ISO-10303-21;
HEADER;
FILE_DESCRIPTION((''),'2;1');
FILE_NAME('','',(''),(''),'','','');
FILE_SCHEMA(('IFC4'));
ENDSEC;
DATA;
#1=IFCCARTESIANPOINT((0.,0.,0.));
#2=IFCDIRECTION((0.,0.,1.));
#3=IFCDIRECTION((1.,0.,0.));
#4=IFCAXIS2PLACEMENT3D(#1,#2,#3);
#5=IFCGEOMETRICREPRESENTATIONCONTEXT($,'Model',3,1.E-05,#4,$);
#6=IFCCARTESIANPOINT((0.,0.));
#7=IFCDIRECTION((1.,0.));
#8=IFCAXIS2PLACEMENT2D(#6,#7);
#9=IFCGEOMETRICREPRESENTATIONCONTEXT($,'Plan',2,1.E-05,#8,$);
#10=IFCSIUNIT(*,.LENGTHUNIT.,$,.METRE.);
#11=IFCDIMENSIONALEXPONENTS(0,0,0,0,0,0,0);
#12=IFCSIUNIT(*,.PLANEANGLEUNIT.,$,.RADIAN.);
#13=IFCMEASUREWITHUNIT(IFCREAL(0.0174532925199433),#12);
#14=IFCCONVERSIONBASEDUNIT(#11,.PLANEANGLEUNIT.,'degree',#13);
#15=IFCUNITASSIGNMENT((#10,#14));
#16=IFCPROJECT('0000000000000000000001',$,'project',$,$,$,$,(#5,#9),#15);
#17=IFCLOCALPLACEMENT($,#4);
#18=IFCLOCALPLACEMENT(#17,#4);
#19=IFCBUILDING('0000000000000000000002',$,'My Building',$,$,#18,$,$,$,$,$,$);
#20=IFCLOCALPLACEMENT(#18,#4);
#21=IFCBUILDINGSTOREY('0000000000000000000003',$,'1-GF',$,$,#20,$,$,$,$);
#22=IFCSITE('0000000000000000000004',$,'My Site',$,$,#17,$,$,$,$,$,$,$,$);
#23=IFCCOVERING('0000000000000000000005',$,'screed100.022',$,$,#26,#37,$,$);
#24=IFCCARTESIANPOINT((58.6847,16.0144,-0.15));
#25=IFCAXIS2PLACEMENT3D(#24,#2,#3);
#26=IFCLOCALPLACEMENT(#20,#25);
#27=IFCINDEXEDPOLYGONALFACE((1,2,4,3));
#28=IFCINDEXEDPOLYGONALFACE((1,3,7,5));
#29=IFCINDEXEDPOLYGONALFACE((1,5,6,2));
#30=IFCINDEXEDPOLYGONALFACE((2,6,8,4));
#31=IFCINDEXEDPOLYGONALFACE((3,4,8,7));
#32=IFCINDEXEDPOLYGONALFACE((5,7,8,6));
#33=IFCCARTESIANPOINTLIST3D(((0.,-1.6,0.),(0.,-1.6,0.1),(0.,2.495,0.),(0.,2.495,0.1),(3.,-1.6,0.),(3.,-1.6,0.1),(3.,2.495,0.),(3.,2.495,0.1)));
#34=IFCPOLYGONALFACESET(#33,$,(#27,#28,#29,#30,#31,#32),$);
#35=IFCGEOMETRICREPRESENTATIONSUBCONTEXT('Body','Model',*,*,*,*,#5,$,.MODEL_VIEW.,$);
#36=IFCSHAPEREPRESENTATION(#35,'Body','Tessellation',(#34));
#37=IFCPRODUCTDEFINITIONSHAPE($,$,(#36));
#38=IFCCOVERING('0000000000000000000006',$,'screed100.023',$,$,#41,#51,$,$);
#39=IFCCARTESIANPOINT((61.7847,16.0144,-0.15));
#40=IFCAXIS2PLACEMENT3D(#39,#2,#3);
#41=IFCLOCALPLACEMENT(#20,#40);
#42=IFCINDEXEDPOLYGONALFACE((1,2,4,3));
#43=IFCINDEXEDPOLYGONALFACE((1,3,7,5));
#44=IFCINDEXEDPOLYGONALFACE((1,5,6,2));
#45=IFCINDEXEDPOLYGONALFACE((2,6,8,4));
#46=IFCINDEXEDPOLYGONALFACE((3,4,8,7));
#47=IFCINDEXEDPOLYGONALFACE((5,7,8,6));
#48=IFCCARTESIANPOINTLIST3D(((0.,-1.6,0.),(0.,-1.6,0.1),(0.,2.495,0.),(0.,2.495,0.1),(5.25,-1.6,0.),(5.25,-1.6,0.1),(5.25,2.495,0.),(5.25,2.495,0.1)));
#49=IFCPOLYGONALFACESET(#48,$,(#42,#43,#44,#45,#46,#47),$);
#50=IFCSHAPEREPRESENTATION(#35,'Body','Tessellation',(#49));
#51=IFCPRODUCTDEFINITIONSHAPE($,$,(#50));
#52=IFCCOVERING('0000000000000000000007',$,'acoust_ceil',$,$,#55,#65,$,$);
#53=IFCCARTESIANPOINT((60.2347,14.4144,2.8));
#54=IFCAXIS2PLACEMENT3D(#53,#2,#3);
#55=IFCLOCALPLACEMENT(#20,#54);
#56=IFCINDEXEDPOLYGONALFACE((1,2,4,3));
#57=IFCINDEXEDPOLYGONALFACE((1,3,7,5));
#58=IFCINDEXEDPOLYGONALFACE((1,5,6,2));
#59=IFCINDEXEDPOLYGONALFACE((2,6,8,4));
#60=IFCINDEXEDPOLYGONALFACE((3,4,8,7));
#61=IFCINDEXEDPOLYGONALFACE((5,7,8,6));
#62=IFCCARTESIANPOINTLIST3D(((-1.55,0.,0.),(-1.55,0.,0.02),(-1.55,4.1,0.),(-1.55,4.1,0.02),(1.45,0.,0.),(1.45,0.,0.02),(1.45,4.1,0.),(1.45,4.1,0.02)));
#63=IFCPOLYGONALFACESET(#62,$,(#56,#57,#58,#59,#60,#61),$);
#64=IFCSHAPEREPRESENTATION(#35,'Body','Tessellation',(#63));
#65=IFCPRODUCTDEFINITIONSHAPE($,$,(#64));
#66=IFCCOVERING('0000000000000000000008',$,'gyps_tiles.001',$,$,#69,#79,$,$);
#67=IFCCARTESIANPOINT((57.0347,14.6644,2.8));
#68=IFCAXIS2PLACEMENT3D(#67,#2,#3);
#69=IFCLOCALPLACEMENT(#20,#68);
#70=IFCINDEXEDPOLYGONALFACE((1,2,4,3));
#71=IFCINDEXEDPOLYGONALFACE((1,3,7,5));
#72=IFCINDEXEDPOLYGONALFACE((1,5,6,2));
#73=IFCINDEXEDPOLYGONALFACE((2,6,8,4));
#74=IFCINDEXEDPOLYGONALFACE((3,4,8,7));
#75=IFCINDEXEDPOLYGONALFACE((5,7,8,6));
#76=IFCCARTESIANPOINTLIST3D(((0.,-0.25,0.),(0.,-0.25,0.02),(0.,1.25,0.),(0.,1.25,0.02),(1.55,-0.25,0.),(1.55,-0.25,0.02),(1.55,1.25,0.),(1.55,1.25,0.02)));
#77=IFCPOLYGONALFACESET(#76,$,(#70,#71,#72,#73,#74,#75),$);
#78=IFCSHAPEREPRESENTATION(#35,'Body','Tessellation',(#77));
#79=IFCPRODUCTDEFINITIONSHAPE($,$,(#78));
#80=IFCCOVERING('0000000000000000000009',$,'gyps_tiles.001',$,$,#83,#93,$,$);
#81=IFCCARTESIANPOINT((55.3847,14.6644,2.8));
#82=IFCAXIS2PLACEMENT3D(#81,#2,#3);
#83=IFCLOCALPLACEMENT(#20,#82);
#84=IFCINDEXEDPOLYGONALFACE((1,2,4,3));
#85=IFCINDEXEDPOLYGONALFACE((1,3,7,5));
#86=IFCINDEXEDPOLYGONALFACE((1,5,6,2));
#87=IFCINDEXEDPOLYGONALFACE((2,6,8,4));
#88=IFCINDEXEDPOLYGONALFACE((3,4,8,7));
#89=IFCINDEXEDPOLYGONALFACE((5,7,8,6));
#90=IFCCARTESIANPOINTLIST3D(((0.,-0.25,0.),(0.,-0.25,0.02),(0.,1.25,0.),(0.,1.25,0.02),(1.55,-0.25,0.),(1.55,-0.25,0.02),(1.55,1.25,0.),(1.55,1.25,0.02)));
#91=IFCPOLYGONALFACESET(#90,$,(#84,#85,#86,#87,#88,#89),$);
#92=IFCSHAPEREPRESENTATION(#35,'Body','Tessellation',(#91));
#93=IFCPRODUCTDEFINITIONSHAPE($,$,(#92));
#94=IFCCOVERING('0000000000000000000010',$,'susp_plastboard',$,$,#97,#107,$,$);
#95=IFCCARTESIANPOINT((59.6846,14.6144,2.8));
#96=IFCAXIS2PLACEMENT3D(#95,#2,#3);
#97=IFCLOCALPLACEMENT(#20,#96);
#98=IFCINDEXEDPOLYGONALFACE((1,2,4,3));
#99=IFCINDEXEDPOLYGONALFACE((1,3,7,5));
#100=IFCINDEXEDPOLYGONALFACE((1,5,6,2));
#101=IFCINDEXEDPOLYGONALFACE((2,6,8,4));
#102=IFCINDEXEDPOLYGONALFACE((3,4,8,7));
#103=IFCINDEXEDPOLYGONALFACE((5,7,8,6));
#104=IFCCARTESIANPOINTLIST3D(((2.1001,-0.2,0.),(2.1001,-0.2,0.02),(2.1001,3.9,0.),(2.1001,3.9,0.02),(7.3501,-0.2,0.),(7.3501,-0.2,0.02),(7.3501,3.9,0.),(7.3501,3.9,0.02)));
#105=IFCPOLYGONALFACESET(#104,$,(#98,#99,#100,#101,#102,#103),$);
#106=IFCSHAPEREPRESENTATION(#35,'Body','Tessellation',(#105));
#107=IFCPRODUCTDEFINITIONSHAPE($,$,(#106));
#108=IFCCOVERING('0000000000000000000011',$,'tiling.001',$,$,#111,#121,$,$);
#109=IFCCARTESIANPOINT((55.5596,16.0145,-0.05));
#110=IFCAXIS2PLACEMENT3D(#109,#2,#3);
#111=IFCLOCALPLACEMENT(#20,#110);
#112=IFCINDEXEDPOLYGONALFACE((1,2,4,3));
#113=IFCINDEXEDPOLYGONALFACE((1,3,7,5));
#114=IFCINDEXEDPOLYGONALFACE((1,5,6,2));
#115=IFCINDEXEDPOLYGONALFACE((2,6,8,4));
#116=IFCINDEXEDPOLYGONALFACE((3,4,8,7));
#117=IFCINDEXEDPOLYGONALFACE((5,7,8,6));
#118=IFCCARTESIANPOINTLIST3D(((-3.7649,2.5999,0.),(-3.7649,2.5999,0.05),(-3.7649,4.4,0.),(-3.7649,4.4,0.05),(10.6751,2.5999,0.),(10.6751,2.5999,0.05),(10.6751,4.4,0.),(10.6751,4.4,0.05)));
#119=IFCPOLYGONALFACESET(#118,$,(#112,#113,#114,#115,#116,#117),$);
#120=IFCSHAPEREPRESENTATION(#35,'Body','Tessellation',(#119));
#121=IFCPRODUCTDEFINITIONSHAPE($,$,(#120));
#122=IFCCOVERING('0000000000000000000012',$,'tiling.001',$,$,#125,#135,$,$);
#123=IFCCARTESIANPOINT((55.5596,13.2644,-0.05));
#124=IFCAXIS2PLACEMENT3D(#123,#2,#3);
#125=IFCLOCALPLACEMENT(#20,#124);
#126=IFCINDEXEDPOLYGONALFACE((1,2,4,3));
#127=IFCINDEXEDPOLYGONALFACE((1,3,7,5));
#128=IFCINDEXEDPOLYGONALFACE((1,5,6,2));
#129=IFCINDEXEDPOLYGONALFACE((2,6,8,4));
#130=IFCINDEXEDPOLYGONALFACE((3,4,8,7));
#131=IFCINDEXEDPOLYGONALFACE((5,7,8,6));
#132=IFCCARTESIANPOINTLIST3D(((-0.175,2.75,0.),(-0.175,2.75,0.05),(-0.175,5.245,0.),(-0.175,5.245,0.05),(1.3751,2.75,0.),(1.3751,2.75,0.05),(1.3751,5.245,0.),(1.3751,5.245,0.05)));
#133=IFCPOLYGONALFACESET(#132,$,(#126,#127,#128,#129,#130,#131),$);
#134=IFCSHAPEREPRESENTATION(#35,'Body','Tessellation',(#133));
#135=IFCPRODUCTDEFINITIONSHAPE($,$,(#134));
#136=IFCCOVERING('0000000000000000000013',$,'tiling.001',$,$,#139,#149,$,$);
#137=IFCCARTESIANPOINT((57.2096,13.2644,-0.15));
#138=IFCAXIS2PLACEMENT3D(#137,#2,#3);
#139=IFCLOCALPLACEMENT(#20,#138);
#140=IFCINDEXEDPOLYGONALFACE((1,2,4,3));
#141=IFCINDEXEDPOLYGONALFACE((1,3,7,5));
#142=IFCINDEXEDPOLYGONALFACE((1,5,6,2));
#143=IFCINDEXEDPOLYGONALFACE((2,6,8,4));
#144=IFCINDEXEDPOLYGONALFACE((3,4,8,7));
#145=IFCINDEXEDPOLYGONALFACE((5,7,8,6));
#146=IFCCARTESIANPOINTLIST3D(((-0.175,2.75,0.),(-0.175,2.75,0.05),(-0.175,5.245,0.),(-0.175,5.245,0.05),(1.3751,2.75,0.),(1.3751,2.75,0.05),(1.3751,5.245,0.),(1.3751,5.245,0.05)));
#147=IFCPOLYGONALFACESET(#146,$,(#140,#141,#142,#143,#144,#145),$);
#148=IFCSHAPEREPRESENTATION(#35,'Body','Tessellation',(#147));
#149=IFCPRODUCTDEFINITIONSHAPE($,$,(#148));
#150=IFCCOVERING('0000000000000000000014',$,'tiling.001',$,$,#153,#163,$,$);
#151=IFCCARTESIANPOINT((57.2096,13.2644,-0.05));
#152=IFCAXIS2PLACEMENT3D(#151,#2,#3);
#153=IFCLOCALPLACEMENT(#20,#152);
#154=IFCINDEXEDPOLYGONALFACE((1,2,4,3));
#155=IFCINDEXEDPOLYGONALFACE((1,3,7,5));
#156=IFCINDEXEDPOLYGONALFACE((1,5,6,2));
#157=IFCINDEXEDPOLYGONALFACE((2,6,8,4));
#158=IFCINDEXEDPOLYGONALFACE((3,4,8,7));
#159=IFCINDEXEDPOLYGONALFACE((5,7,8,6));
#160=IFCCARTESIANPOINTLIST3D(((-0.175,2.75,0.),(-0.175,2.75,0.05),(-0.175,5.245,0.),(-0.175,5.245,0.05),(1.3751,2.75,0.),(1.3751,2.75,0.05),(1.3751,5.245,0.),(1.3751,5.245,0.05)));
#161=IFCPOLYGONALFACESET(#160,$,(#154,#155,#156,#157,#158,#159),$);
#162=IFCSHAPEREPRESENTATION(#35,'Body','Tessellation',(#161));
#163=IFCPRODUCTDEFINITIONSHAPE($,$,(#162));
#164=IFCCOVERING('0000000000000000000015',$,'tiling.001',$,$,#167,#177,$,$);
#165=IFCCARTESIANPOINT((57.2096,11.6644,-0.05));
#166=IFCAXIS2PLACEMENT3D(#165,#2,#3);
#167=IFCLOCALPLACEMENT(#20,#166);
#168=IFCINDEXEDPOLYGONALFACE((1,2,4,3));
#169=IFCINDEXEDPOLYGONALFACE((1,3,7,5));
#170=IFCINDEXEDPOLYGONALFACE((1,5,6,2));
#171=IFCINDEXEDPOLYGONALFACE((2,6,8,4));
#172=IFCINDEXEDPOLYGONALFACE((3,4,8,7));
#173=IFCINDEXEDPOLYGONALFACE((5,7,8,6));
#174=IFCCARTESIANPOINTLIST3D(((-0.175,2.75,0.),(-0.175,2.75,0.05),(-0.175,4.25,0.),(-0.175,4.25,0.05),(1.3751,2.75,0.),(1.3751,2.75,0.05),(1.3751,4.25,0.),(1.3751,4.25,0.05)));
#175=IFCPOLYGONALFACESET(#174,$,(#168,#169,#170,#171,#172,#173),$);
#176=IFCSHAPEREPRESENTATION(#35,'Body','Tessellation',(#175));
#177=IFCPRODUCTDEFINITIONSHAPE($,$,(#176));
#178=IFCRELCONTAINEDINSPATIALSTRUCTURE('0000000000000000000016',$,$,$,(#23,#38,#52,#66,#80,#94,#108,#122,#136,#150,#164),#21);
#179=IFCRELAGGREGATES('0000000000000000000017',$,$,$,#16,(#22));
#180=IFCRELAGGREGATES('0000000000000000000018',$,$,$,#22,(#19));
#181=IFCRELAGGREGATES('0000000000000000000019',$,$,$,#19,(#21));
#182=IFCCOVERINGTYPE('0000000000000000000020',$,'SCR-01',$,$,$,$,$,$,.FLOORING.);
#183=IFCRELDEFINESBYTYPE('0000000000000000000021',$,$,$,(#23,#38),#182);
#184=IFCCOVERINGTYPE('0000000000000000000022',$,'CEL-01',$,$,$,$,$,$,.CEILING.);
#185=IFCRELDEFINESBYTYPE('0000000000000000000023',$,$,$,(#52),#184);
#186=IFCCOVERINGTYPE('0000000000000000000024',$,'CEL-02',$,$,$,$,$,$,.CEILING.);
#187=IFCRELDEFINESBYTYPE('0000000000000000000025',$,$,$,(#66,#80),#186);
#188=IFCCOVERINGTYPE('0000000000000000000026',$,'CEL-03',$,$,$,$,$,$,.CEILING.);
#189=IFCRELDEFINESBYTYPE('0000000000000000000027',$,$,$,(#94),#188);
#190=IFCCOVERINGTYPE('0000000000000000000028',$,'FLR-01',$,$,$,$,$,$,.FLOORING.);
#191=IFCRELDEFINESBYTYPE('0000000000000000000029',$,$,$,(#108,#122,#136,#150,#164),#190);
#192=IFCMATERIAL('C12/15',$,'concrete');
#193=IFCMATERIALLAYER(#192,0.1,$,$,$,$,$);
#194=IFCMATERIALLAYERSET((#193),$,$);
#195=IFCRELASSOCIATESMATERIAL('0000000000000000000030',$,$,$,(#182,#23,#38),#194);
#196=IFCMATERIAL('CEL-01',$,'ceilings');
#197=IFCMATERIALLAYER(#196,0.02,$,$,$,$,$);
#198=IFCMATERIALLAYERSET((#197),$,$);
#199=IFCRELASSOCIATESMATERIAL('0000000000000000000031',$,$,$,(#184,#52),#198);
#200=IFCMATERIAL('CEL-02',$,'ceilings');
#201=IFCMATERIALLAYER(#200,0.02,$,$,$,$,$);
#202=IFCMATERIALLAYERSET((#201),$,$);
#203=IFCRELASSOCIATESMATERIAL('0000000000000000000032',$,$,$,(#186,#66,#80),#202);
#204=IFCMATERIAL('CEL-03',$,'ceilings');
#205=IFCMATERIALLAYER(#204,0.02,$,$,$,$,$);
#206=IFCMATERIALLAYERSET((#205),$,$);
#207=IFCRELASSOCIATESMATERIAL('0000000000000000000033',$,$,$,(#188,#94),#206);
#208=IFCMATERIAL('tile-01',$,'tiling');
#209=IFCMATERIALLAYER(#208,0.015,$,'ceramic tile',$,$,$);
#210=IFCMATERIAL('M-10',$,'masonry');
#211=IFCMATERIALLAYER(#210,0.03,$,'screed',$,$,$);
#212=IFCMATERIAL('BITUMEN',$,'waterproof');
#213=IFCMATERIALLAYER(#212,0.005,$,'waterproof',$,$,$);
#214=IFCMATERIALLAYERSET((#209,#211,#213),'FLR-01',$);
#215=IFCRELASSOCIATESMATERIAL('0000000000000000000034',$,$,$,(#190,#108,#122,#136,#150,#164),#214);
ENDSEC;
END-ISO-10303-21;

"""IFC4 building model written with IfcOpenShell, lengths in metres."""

from ifc_helpers import new_model, entity, si_unit, converted_unit, frame, origin_with_axes, origin_2d_with_axis, place, context, subcontext, project, spatial, line, indexed_curve, outline, extrude, material, layer, layer_set, layer_usage, type_object, element, save


model = new_model("IFC4")

# Units and contexts
model_context = context("Model", 3, precision=1e-05, world=origin_with_axes())
plan_context = context("Plan", 2, precision=1e-05, world=origin_2d_with_axis())
body_context_1 = subcontext(model_context, "Body", "Model", "MODEL_VIEW")
ifc_project = project(units=[si_unit("LENGTHUNIT", "METRE"), converted_unit("PLANEANGLEUNIT", "degree", entity("IfcReal", 0.0174532925199433), si_unit("PLANEANGLEUNIT", "RADIAN"), dimensions=[0, 0, 0, 0, 0, 0, 0])], contexts=[model_context, plan_context])

# Site, building, storey
site_placement = place(None, origin_with_axes())
site = spatial("IfcSite", under=ifc_project, at=site_placement, Name="My Site")
building_placement = place(site_placement, origin_with_axes())
building = spatial("IfcBuilding", under=site, at=building_placement, Name="My Building")
storey_placement = place(building_placement, origin_with_axes())
storey = spatial("IfcBuildingStorey", under=building, at=storey_placement, Name="1-GF")

# Coverings
ifc_material_1 = material(Name="C12/15", Category="concrete")
ifc_layer_1 = layer(ifc_material_1, 0.1)
ifc_layer_set_1 = layer_set([ifc_layer_1])
covering_type_1 = type_object("IfcCoveringType", Name="SCR-01", PredefinedType="FLOORING", material=ifc_layer_set_1)
ifc_layer_usage_1 = layer_usage(ifc_layer_set_1, "AXIS3", "POSITIVE", 0.0)
covering_1_placement = place(storey_placement, frame((58.6847, 16.0144, -0.15), z_axis=(0.0, 0.0, 1.0), x_axis=(1.0, 0.0, 0.0)))
element("IfcCovering", 1, at=covering_1_placement, inside=storey, type_object=covering_type_1, material=ifc_layer_usage_1, Name="screed100.022", context=body_context_1, shape_type="SweptSolid", body=[
    extrude(outline(indexed_curve([(3.0, 2.495), (3.0, -1.6), (0.0, -1.6), (0.0, 2.495)], segments=[line(4, 1), line(1, 2), line(2, 3), line(3, 4)], self_intersect=False)), None, (0.0, 0.0, 1.0), 0.1),
])
ifc_layer_usage_2 = layer_usage(ifc_layer_set_1, "AXIS3", "POSITIVE", 0.0)
covering_2_placement = place(storey_placement, frame((61.7847, 16.0144, -0.15), z_axis=(0.0, 0.0, 1.0), x_axis=(1.0, 0.0, 0.0)))
element("IfcCovering", 2, at=covering_2_placement, inside=storey, type_object=covering_type_1, material=ifc_layer_usage_2, Name="screed100.023", context=body_context_1, shape_type="SweptSolid", body=[
    extrude(outline(indexed_curve([(0.0, 2.495), (5.25, 2.495), (5.25, -1.6), (0.0, -1.6)], segments=[line(3, 2), line(2, 1), line(1, 4), line(4, 3)], self_intersect=False)), None, (0.0, 0.0, 1.0), 0.1),
])
ifc_material_2 = material(Name="CEL-01", Category="ceilings")
ifc_layer_2 = layer(ifc_material_2, 0.02)
ifc_layer_set_2 = layer_set([ifc_layer_2])
ifc_layer_usage_3 = layer_usage(ifc_layer_set_2, "AXIS3", "POSITIVE", 0.0)
covering_type_2 = type_object("IfcCoveringType", Name="CEL-01", PredefinedType="CEILING", material=ifc_layer_set_2)
covering_3_placement = place(storey_placement, frame((60.2347, 14.4144, 2.8), z_axis=(0.0, 0.0, 1.0), x_axis=(1.0, 0.0, 0.0)))
element("IfcCovering", 3, at=covering_3_placement, inside=storey, type_object=covering_type_2, material=ifc_layer_usage_3, Name="acoust_ceil", context=body_context_1, shape_type="SweptSolid", body=[
    extrude(outline(indexed_curve([(-1.55, 0.0), (1.45, 0.0), (1.45, 4.1), (-1.55, 4.1)], segments=[line(3, 2), line(2, 1), line(1, 4), line(4, 3)], self_intersect=False)), None, (0.0, 0.0, 1.0), 0.02),
])
ifc_material_3 = material(Name="CEL-02", Category="ceilings")
ifc_layer_3 = layer(ifc_material_3, 0.02)
ifc_layer_set_3 = layer_set([ifc_layer_3])
ifc_layer_usage_4 = layer_usage(ifc_layer_set_3, "AXIS3", "POSITIVE", 0.0)
covering_type_3 = type_object("IfcCoveringType", Name="CEL-02", PredefinedType="CEILING", material=ifc_layer_set_3)
covering_4_placement = place(storey_placement, frame((57.0347, 14.6644, 2.8), z_axis=(0.0, 0.0, 1.0), x_axis=(1.0, 0.0, 0.0)))
element("IfcCovering", 4, at=covering_4_placement, inside=storey, type_object=covering_type_3, material=ifc_layer_usage_4, Name="gyps_tiles.001", context=body_context_1, shape_type="SweptSolid", body=[
    extrude(outline(indexed_curve([(0.0, -0.25), (1.55, -0.25), (1.55, 1.25), (0.0, 1.25)], segments=[line(3, 2), line(2, 1), line(1, 4), line(4, 3)], self_intersect=False)), None, (0.0, 0.0, 1.0), 0.02),
])
ifc_layer_usage_5 = layer_usage(ifc_layer_set_3, "AXIS3", "POSITIVE", 0.0)
covering_5_placement = place(storey_placement, frame((55.3847, 14.6644, 2.8), z_axis=(0.0, 0.0, 1.0), x_axis=(1.0, 0.0, 0.0)))
element("IfcCovering", 5, at=covering_5_placement, inside=storey, type_object=covering_type_3, material=ifc_layer_usage_5, Name="gyps_tiles.001", context=body_context_1, shape_type="SweptSolid", body=[
    extrude(outline(indexed_curve([(0.0, -0.25), (1.55, -0.25), (1.55, 1.25), (0.0, 1.25)], segments=[line(3, 2), line(2, 1), line(1, 4), line(4, 3)], self_intersect=False)), None, (0.0, 0.0, 1.0), 0.02),
])
ifc_material_4 = material(Name="CEL-03", Category="ceilings")
ifc_layer_4 = layer(ifc_material_4, 0.02)
ifc_layer_set_4 = layer_set([ifc_layer_4])
ifc_layer_usage_6 = layer_usage(ifc_layer_set_4, "AXIS3", "POSITIVE", 0.0)
covering_type_4 = type_object("IfcCoveringType", Name="CEL-03", PredefinedType="CEILING", material=ifc_layer_set_4)
covering_6_placement = place(storey_placement, frame((59.6846, 14.6144, 2.8), z_axis=(0.0, 0.0, 1.0), x_axis=(1.0, 0.0, 0.0)))
element("IfcCovering", 6, at=covering_6_placement, inside=storey, type_object=covering_type_4, material=ifc_layer_usage_6, Name="susp_plastboard", context=body_context_1, shape_type="SweptSolid", body=[
    extrude(outline(indexed_curve([(2.1001, 3.9), (2.1001, -0.2), (7.3501, -0.2), (7.3501, 3.9)], segments=[line(3, 2), line(2, 1), line(1, 4), line(4, 3)], self_intersect=False)), None, (0.0, 0.0, 1.0), 0.02),
])
ifc_material_5 = material(Name="tile-01", Category="tiling")
ifc_layer_5 = layer(ifc_material_5, 0.015, Name="ceramic tile")
ifc_material_6 = material(Name="M-10", Category="masonry")
ifc_layer_6 = layer(ifc_material_6, 0.03, Name="screed")
ifc_material_7 = material(Name="BITUMEN", Category="waterproof")
ifc_layer_7 = layer(ifc_material_7, 0.005, Name="waterproof")
ifc_layer_set_5 = layer_set([ifc_layer_5, ifc_layer_6, ifc_layer_7], Name="FLR-01")
ifc_layer_usage_7 = layer_usage(ifc_layer_set_5, "AXIS3", "POSITIVE", 0.0)
covering_type_5 = type_object("IfcCoveringType", Name="FLR-01", PredefinedType="FLOORING", material=ifc_layer_set_5)
covering_7_placement = place(storey_placement, frame((55.5596, 16.0145, -0.05), z_axis=(0.0, 0.0, 1.0), x_axis=(1.0, 0.0, 0.0)))
element("IfcCovering", 7, at=covering_7_placement, inside=storey, type_object=covering_type_5, material=ifc_layer_usage_7, Name="tiling.001", context=body_context_1, shape_type="SweptSolid", body=[
    extrude(outline(indexed_curve([(-3.7649, 2.5999), (-3.7649, 4.4), (10.6751, 4.4), (10.6751, 2.5999)], segments=[line(4, 1), line(1, 2), line(2, 3), line(3, 4)], self_intersect=False)), None, (0.0, 0.0, 1.0), 0.05),
])
ifc_layer_usage_8 = layer_usage(ifc_layer_set_5, "AXIS3", "POSITIVE", 0.0)
covering_8_placement = place(storey_placement, frame((55.5596, 13.2644, -0.05), z_axis=(0.0, 0.0, 1.0), x_axis=(1.0, 0.0, 0.0)))
element("IfcCovering", 8, at=covering_8_placement, inside=storey, type_object=covering_type_5, material=ifc_layer_usage_8, Name="tiling.001", context=body_context_1, shape_type="SweptSolid", body=[
    extrude(outline(indexed_curve([(-0.175, 2.75), (-0.175, 5.245), (1.3751, 5.245), (1.3751, 2.75)], segments=[line(3, 2), line(2, 1), line(1, 4), line(4, 3)], self_intersect=False)), None, (0.0, 0.0, 1.0), 0.05),
])
ifc_layer_usage_9 = layer_usage(ifc_layer_set_5, "AXIS3", "POSITIVE", 0.0)
covering_9_placement = place(storey_placement, frame((57.2096, 13.2644, -0.15), z_axis=(0.0, 0.0, 1.0), x_axis=(1.0, 0.0, 0.0)))
element("IfcCovering", 9, at=covering_9_placement, inside=storey, type_object=covering_type_5, material=ifc_layer_usage_9, Name="tiling.001", context=body_context_1, shape_type="SweptSolid", body=[
    extrude(outline(indexed_curve([(-0.175, 2.75), (-0.175, 5.245), (1.3751, 5.245), (1.3751, 2.75)], segments=[line(3, 2), line(2, 1), line(1, 4), line(4, 3)], self_intersect=False)), None, (0.0, 0.0, 1.0), 0.05),
])
ifc_layer_usage_10 = layer_usage(ifc_layer_set_5, "AXIS3", "POSITIVE", 0.0)
covering_10_placement = place(storey_placement, frame((57.2096, 13.2644, -0.05), z_axis=(0.0, 0.0, 1.0), x_axis=(1.0, 0.0, 0.0)))
element("IfcCovering", 10, at=covering_10_placement, inside=storey, type_object=covering_type_5, material=ifc_layer_usage_10, Name="tiling.001", context=body_context_1, shape_type="SweptSolid", body=[
    extrude(outline(indexed_curve([(-0.175, 2.75), (-0.175, 5.245), (1.3751, 5.245), (1.3751, 2.75)], segments=[line(3, 2), line(2, 1), line(1, 4), line(4, 3)], self_intersect=False)), None, (0.0, 0.0, 1.0), 0.05),
])
ifc_layer_usage_11 = layer_usage(ifc_layer_set_5, "AXIS3", "POSITIVE", 0.0)
covering_11_placement = place(storey_placement, frame((57.2096, 11.6644, -0.05), z_axis=(0.0, 0.0, 1.0), x_axis=(1.0, 0.0, 0.0)))
element("IfcCovering", 11, at=covering_11_placement, inside=storey, type_object=covering_type_5, material=ifc_layer_usage_11, Name="tiling.001", context=body_context_1, shape_type="SweptSolid", body=[
    extrude(outline(indexed_curve([(1.3751, 4.25), (-0.175, 4.25), (-0.175, 2.75), (1.3751, 2.75)], segments=[line(3, 2), line(2, 1), line(1, 4), line(4, 3)], self_intersect=False)), None, (0.0, 0.0, 1.0), 0.05),
])

save(model, "model.ifc")
